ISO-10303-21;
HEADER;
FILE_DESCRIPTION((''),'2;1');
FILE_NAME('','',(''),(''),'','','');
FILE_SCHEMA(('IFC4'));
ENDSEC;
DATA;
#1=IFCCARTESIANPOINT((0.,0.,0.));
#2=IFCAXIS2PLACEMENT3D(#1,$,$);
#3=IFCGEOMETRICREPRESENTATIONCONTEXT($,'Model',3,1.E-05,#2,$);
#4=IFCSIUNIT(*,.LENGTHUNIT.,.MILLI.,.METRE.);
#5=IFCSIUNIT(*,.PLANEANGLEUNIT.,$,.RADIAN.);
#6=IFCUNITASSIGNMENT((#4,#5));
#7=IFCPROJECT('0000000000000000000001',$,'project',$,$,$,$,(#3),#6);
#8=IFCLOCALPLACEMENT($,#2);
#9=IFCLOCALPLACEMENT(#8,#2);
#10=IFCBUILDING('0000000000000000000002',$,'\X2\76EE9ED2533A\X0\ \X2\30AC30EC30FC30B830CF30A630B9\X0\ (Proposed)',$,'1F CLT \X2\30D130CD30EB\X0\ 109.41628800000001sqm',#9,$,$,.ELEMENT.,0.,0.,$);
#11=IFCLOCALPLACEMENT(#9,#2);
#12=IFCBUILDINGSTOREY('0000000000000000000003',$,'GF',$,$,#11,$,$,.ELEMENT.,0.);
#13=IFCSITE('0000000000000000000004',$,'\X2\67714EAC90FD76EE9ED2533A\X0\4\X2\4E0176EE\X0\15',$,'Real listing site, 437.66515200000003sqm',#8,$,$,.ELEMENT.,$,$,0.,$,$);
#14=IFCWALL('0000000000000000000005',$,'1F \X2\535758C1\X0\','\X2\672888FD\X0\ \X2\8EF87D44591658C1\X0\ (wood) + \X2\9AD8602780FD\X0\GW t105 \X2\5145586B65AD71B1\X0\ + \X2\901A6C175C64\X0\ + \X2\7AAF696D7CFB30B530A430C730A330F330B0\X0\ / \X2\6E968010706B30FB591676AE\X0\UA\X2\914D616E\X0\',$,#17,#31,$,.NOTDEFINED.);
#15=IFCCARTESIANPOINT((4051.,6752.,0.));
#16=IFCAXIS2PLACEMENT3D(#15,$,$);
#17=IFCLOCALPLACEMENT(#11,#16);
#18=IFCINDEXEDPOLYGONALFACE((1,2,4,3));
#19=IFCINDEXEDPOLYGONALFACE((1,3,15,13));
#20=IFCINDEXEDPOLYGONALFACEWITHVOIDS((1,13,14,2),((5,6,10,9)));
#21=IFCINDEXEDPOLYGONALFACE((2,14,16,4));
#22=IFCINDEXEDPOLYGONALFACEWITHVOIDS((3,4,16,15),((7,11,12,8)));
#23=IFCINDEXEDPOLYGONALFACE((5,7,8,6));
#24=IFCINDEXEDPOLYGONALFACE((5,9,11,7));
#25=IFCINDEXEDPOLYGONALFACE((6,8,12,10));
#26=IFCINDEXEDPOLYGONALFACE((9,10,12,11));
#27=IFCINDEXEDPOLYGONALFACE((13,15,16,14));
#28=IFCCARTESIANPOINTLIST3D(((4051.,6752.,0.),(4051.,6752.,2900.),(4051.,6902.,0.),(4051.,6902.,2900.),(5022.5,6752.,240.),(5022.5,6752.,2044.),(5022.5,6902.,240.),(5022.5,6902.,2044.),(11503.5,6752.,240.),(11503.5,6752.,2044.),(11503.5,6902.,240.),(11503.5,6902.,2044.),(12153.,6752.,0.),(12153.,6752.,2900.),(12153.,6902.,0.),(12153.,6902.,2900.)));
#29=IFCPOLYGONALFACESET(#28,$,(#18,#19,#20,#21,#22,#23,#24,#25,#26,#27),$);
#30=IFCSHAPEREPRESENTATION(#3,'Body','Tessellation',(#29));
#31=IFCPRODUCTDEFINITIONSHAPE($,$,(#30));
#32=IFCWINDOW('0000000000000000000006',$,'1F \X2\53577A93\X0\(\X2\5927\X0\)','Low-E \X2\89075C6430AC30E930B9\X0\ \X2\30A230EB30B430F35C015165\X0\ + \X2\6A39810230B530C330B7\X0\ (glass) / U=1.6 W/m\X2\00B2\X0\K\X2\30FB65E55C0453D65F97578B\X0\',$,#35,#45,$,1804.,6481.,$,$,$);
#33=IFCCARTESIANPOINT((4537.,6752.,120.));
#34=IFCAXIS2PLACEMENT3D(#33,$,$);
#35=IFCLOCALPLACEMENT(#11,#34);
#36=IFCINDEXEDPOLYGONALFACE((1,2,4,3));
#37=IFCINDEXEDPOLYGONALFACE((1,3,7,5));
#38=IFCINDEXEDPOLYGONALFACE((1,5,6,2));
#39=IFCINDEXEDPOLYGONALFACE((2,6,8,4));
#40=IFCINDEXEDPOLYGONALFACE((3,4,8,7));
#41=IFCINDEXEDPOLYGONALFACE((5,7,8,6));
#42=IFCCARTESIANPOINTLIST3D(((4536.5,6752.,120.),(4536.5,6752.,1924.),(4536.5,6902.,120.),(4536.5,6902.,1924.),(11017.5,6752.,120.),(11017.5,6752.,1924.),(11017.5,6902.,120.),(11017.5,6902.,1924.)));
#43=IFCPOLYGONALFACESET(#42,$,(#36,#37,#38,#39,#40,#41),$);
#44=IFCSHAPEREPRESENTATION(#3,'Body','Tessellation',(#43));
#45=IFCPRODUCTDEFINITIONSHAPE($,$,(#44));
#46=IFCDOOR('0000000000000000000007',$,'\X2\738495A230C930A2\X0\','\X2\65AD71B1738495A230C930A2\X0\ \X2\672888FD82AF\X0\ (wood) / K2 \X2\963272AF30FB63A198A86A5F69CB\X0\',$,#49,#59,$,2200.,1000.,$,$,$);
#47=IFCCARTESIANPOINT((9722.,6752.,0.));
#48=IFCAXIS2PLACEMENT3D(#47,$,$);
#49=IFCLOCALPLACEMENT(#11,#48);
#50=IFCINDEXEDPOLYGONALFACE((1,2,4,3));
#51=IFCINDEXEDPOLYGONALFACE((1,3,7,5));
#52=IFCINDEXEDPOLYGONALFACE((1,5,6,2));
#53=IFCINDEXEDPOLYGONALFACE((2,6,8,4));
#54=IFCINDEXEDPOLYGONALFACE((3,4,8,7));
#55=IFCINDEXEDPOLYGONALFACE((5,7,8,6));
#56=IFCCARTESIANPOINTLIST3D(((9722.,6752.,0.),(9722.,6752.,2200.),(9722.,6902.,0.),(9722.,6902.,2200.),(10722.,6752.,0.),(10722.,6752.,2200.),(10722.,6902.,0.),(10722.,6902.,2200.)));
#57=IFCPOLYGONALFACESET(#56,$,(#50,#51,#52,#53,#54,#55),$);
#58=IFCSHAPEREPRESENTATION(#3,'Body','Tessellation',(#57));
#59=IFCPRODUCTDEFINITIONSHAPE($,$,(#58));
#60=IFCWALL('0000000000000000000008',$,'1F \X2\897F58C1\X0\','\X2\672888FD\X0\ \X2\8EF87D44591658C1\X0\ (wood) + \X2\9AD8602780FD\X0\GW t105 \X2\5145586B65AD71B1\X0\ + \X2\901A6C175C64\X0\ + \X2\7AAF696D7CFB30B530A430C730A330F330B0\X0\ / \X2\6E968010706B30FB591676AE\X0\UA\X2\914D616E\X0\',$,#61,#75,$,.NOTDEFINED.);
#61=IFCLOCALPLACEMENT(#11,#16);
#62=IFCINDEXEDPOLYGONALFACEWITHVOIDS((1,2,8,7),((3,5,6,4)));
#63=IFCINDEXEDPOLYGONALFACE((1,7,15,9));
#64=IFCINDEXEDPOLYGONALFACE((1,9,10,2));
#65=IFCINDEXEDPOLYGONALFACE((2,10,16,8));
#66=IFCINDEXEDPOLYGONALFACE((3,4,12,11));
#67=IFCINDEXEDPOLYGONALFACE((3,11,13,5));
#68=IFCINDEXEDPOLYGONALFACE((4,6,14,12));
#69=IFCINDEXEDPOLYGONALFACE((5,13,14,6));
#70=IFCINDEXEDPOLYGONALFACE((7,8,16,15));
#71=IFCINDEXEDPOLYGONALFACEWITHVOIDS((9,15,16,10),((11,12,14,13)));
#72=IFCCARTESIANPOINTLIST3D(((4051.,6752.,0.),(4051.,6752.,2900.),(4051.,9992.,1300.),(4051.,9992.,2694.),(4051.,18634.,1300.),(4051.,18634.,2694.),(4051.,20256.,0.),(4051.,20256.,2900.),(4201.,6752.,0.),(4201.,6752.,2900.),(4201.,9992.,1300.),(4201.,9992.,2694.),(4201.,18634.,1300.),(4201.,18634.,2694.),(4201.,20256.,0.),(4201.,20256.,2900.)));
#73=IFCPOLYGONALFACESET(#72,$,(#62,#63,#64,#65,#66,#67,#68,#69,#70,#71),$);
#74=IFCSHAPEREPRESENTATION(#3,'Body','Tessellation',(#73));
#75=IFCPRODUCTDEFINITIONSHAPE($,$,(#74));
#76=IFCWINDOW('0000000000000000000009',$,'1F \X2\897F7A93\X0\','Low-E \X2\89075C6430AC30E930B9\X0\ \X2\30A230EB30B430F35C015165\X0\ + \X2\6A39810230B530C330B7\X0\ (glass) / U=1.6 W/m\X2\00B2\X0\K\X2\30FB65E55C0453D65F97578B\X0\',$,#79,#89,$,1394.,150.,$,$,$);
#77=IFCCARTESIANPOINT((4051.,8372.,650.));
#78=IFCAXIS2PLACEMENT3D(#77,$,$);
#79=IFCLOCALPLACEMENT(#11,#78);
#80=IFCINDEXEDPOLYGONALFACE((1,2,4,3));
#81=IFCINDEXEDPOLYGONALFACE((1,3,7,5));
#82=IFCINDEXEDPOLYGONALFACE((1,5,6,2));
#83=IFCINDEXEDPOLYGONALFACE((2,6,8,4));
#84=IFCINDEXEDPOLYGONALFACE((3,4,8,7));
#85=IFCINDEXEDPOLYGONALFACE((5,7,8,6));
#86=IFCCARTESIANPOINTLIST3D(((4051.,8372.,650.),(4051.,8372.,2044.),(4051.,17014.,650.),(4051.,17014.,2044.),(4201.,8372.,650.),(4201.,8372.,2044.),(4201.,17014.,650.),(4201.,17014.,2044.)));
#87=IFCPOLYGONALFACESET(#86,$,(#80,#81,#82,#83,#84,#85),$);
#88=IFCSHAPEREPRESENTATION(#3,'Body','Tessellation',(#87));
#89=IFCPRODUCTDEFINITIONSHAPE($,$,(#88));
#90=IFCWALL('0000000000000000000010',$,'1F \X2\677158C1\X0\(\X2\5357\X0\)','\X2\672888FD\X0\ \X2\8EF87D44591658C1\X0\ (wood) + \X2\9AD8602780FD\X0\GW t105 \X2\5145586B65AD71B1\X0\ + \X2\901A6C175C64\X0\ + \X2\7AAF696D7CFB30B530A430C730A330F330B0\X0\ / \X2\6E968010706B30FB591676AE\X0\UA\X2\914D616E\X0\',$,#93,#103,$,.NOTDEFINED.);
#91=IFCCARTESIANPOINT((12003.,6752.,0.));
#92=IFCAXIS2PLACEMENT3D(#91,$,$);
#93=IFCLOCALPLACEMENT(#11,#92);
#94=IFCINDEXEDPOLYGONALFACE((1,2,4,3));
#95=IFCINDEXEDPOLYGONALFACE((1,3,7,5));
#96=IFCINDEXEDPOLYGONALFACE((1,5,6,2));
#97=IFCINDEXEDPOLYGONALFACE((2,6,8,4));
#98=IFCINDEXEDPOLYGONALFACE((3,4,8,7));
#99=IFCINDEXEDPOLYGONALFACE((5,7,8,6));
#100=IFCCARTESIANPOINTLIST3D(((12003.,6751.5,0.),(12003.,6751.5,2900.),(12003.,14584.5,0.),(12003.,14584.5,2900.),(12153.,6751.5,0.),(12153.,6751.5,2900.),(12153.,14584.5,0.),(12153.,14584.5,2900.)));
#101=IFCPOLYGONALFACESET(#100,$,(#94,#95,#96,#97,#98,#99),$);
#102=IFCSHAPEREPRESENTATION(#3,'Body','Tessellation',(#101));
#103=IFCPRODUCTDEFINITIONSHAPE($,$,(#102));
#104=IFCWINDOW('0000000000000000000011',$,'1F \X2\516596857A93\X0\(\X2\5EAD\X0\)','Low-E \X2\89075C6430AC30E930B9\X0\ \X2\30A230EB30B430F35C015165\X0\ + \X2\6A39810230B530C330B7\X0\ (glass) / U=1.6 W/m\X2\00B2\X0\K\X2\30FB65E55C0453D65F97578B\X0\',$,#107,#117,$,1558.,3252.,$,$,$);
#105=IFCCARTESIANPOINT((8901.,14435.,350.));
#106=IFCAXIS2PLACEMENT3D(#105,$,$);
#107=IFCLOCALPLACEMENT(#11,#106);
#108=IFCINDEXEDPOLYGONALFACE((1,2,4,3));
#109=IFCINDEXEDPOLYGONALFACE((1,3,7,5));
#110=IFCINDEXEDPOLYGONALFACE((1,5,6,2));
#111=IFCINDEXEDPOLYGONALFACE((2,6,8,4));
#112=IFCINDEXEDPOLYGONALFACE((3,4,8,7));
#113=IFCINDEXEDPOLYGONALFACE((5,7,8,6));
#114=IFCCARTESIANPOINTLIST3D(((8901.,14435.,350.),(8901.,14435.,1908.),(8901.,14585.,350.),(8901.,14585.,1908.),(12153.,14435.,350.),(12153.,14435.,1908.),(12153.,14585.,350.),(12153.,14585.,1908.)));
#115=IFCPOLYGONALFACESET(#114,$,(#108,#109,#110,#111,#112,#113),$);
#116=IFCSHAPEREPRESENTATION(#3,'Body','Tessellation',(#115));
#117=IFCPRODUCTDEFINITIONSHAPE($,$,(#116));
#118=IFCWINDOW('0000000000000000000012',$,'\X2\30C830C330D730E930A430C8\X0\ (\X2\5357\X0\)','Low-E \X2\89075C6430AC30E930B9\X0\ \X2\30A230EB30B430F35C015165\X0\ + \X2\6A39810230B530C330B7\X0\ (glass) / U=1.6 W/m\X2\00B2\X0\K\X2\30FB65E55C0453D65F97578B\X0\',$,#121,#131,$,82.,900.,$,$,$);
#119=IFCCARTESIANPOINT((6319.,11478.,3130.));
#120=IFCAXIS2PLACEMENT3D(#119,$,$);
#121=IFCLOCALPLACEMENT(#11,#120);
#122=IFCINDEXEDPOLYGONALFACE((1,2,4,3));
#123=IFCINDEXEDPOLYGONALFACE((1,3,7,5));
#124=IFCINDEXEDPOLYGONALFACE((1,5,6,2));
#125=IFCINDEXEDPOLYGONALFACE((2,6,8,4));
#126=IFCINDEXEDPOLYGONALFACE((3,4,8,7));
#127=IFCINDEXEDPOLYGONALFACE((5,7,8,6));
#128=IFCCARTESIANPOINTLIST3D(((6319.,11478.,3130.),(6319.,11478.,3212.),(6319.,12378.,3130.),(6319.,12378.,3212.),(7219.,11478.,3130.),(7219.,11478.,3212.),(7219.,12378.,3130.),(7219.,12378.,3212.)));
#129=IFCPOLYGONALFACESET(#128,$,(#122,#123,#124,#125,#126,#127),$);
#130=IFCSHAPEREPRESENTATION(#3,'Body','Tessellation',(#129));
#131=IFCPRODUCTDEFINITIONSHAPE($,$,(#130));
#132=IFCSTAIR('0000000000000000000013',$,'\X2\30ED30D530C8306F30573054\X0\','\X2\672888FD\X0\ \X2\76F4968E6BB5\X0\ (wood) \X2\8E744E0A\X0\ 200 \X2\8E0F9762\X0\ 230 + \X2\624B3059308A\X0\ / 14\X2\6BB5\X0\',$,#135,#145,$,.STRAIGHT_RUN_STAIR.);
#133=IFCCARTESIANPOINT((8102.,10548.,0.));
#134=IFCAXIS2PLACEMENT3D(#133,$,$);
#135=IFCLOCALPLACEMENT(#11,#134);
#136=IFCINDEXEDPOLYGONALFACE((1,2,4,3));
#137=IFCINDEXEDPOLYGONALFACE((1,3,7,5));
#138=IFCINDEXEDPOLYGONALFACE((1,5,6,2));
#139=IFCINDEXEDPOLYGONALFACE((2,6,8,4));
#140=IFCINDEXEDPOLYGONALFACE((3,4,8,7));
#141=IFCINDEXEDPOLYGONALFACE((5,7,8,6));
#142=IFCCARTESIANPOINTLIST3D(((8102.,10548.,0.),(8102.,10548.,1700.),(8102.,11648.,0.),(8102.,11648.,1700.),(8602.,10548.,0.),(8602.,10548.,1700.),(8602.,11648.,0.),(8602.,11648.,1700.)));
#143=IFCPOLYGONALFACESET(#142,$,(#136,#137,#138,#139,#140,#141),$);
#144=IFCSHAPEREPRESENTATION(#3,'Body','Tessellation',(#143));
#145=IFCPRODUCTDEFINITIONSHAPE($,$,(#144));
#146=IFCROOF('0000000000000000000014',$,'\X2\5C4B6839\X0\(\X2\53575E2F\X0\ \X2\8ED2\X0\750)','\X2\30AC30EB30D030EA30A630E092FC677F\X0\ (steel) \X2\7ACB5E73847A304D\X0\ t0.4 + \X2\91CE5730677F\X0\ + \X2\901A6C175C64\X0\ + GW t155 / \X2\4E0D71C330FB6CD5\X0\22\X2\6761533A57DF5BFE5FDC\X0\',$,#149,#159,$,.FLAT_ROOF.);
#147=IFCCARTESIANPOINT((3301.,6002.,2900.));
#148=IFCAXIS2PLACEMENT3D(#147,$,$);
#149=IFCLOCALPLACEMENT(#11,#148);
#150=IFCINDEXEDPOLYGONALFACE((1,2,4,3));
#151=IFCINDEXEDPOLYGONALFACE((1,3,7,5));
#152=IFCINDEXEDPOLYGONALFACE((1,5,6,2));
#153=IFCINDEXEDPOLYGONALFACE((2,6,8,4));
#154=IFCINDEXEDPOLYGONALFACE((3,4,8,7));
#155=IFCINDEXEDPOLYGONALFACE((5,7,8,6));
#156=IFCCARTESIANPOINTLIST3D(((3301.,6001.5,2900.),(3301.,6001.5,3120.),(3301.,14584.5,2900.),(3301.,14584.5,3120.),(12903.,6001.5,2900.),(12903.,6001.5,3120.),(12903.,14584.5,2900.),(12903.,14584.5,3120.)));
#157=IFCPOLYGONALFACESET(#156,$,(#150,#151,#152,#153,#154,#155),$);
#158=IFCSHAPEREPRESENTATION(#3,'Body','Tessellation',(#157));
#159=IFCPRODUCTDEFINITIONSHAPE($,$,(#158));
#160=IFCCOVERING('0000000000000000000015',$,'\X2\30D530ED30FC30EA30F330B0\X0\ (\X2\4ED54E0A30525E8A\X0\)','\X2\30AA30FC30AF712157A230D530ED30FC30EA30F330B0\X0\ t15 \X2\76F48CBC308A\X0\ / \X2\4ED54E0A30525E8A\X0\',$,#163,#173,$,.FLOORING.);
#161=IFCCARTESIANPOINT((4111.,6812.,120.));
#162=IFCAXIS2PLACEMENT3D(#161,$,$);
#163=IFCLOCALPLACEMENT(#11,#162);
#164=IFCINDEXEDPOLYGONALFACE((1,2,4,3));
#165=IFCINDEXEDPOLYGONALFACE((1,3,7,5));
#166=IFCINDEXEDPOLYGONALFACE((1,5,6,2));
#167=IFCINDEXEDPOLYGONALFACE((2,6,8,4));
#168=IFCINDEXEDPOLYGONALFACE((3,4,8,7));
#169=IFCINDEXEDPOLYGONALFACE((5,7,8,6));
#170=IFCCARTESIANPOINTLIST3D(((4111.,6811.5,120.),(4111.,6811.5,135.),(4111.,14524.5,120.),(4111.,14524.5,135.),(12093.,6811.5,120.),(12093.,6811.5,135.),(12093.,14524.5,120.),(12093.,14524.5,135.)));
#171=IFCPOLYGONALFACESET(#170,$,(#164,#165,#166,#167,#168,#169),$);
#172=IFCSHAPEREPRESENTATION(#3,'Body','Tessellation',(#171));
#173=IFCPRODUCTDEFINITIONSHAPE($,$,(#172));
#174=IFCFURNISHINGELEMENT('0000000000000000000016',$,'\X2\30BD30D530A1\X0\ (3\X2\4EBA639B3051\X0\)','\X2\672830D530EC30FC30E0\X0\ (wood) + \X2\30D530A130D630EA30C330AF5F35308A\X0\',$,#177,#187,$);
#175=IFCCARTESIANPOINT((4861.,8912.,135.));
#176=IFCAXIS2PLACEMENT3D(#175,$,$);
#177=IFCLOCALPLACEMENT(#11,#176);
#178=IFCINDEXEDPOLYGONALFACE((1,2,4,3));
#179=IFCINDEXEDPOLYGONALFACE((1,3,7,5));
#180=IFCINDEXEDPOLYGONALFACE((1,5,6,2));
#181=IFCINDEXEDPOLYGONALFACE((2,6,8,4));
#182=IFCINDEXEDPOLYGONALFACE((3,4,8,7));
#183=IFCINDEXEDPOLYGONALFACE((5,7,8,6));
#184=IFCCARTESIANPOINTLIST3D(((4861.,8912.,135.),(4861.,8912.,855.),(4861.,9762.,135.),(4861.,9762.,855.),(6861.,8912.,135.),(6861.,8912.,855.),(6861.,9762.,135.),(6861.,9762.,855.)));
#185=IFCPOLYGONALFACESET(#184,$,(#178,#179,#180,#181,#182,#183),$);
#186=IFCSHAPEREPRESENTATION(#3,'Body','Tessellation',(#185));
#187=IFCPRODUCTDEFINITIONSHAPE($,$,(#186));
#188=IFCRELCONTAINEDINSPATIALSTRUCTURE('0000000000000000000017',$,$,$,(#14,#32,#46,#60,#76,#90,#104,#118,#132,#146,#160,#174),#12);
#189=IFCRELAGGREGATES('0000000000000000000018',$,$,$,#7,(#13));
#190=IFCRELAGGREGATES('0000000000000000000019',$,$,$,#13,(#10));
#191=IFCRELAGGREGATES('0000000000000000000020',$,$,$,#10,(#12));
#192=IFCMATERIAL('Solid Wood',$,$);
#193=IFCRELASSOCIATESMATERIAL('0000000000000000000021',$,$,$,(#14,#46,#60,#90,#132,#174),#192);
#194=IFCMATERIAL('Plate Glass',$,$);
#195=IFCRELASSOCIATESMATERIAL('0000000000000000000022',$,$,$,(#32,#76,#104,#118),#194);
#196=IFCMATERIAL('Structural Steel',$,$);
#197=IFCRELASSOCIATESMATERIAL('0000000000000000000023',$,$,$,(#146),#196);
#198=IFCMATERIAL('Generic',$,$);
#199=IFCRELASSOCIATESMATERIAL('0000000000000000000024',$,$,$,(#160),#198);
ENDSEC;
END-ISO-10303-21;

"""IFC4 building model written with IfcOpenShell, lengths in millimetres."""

from ifc_helpers import new_model, si_unit, frame, frame_2d, origin, place, context, project, spatial, rectangle, extrude, material, element, fill, save


model = new_model("IFC4")

# Units and contexts
model_context = context("Model", 3, precision=1e-05, world=origin())
ifc_project = project(units=[si_unit("LENGTHUNIT", "METRE", prefix="MILLI"), si_unit("PLANEANGLEUNIT", "RADIAN")], contexts=[model_context])

# Site, building, storey
site_placement = place(None, origin())
site = spatial("IfcSite", under=ifc_project, at=site_placement, Name="東京都目黒区4丁目15", ObjectType="Real listing site, 437.66515200000003sqm", CompositionType="ELEMENT", RefElevation=0.0)
building_placement = place(site_placement, origin())
building = spatial("IfcBuilding", under=site, at=building_placement, Name="目黒区 ガレージハウス (Proposed)", ObjectType="1F CLT パネル 109.41628800000001sqm", CompositionType="ELEMENT", ElevationOfRefHeight=0.0, ElevationOfTerrain=0.0)
storey_placement = place(building_placement, origin())
storey = spatial("IfcBuildingStorey", under=building, at=storey_placement, Name="GF", CompositionType="ELEMENT", Elevation=0.0)

# Shared definitions
ifc_material_1 = material(Name="Solid Wood")

# Wall, openings, window, door
wall_1_placement = place(storey_placement, frame((4051.0, 6752.0, 0.0)))
wall_1 = element("IfcWall", 1, at=wall_1_placement, inside=storey, material=ifc_material_1, Name="1F 南壁", Description="木製 軸組外壁 (wood) + 高性能GW t105 充填断熱 + 通気層 + 窯業系サイディング / 準耐火・外皮UA配慮", PredefinedType="NOTDEFINED", context=model_context, shape_type="SweptSolid", body=[
    extrude(rectangle(XDim=8102.0, YDim=150.0, at=frame_2d((4051.0, 75.0))), frame((4051.0, 6752.0, 0.0)), (0.0, 0.0, 1.0), 2900.0),
])
opening_1_placement = place(storey_placement, frame((4537.0, 6752.0, 120.0)))
opening_1 = element("IfcOpeningElement", 2, at=opening_1_placement, cuts=wall_1, PredefinedType="NOTDEFINED", context=model_context, shape_type="SweptSolid", body=[
    extrude(rectangle(XDim=6481.0, YDim=150.0, at=frame_2d((3240.0, 75.0))), frame((4537.0, 6752.0, 120.0)), (0.0, 0.0, 1.0), 1804.0),
])
opening_2_placement = place(storey_placement, frame((9722.0, 6752.0, 0.0)))
opening_2 = element("IfcOpeningElement", 3, at=opening_2_placement, cuts=wall_1, PredefinedType="NOTDEFINED", context=model_context, shape_type="SweptSolid", body=[
    extrude(rectangle(XDim=1000.0, YDim=150.0, at=frame_2d((500.0, 75.0))), frame((9722.0, 6752.0, 0.0)), (0.0, 0.0, 1.0), 2200.0),
])
ifc_material_2 = material(Name="Plate Glass")
window_1_placement = place(storey_placement, frame((4537.0, 6752.0, 120.0)))
window_1 = element("IfcWindow", 4, at=window_1_placement, inside=storey, material=ifc_material_2, Name="1F 南窓(大)", Description="Low-E 複層ガラス アルゴン封入 + 樹脂サッシ (glass) / U=1.6 W/m²K・日射取得型", OverallHeight=1804.0, OverallWidth=6481.0, context=model_context, shape_type="SweptSolid", body=[
    extrude(rectangle(XDim=6481.0, YDim=150.0, at=frame_2d((3240.0, 75.0))), frame((4537.0, 6752.0, 120.0)), (0.0, 0.0, 1.0), 1804.0),
])
fill(opening_1, window_1)
door_1_placement = place(storey_placement, frame((9722.0, 6752.0, 0.0)))
door_1 = element("IfcDoor", 5, at=door_1_placement, inside=storey, material=ifc_material_1, Name="玄関ドア", Description="断熱玄関ドア 木製芯 (wood) / K2 防犯・採風機構", OverallHeight=2200.0, OverallWidth=1000.0, context=model_context, shape_type="SweptSolid", body=[
    extrude(rectangle(XDim=1000.0, YDim=150.0, at=frame_2d((500.0, 75.0))), frame((9722.0, 6752.0, 0.0)), (0.0, 0.0, 1.0), 2200.0),
])
fill(opening_2, door_1)

# Walls, openings, windows
wall_2_placement = place(storey_placement, frame((4051.0, 6752.0, 0.0)))
wall_2 = element("IfcWall", 6, at=wall_2_placement, inside=storey, material=ifc_material_1, Name="1F 西壁", Description="木製 軸組外壁 (wood) + 高性能GW t105 充填断熱 + 通気層 + 窯業系サイディング / 準耐火・外皮UA配慮", PredefinedType="NOTDEFINED", context=model_context, shape_type="SweptSolid", body=[
    extrude(rectangle(XDim=150.0, YDim=13504.0, at=frame_2d((75.0, 6752.0))), frame((4051.0, 6752.0, 0.0)), (0.0, 0.0, 1.0), 2900.0),
])
opening_3_placement = place(storey_placement, frame((4051.0, 8372.0, 650.0)))
opening_3 = element("IfcOpeningElement", 7, at=opening_3_placement, cuts=wall_2, PredefinedType="NOTDEFINED", context=model_context, shape_type="SweptSolid", body=[
    extrude(rectangle(XDim=150.0, YDim=8642.0, at=frame_2d((75.0, 4321.0))), frame((4051.0, 8372.0, 650.0)), (0.0, 0.0, 1.0), 1394.0),
])
window_2_placement = place(storey_placement, frame((4051.0, 8372.0, 650.0)))
window_2 = element("IfcWindow", 8, at=window_2_placement, inside=storey, material=ifc_material_2, Name="1F 西窓", Description="Low-E 複層ガラス アルゴン封入 + 樹脂サッシ (glass) / U=1.6 W/m²K・日射取得型", OverallHeight=1394.0, OverallWidth=150.0, context=model_context, shape_type="SweptSolid", body=[
    extrude(rectangle(XDim=150.0, YDim=8642.0, at=frame_2d((75.0, 4321.0))), frame((4051.0, 8372.0, 650.0)), (0.0, 0.0, 1.0), 1394.0),
])
fill(opening_3, window_2)
wall_3_placement = place(storey_placement, frame((12003.0, 6752.0, 0.0)))
wall_3 = element("IfcWall", 9, at=wall_3_placement, inside=storey, material=ifc_material_1, Name="1F 東壁(南)", Description="木製 軸組外壁 (wood) + 高性能GW t105 充填断熱 + 通気層 + 窯業系サイディング / 準耐火・外皮UA配慮", PredefinedType="NOTDEFINED", context=model_context, shape_type="SweptSolid", body=[
    extrude(rectangle(XDim=150.0, YDim=7833.0, at=frame_2d((75.0, 3916.0))), frame((12003.0, 6752.0, 0.0)), (0.0, 0.0, 1.0), 2900.0),
])
opening_4_placement = place(storey_placement, frame((8901.0, 14435.0, 350.0)))
opening_4 = element("IfcOpeningElement", 10, at=opening_4_placement, cuts=wall_3, PredefinedType="NOTDEFINED", context=model_context, shape_type="SweptSolid", body=[
    extrude(rectangle(XDim=3252.0, YDim=150.0, at=frame_2d((1626.0, 75.0))), frame((8901.0, 14435.0, 350.0)), (0.0, 0.0, 1.0), 1558.0),
])
window_3_placement = place(storey_placement, frame((8901.0, 14435.0, 350.0)))
window_3 = element("IfcWindow", 11, at=window_3_placement, inside=storey, material=ifc_material_2, Name="1F 入隅窓(庭)", Description="Low-E 複層ガラス アルゴン封入 + 樹脂サッシ (glass) / U=1.6 W/m²K・日射取得型", OverallHeight=1558.0, OverallWidth=3252.0, context=model_context, shape_type="SweptSolid", body=[
    extrude(rectangle(XDim=3252.0, YDim=150.0, at=frame_2d((1626.0, 75.0))), frame((8901.0, 14435.0, 350.0)), (0.0, 0.0, 1.0), 1558.0),
])
fill(opening_4, window_3)

# Window
window_4_placement = place(storey_placement, frame((6319.0, 11478.0, 3130.0)))
element("IfcWindow", 12, at=window_4_placement, inside=storey, material=ifc_material_2, Name="トップライト (南)", Description="Low-E 複層ガラス アルゴン封入 + 樹脂サッシ (glass) / U=1.6 W/m²K・日射取得型", OverallHeight=82.0, OverallWidth=900.0, context=model_context, shape_type="SweptSolid", body=[
    extrude(rectangle(XDim=900.0, YDim=900.0, at=frame_2d((450.0, 450.0))), frame((6319.0, 11478.0, 3130.0)), (0.0, 0.0, 1.0), 82.0),
])

# Stair
stair_placement = place(storey_placement, frame((8102.0, 10548.0, 0.0)))
element("IfcStair", 13, at=stair_placement, inside=storey, material=ifc_material_1, Name="ロフトはしご", Description="木製 直階段 (wood) 蹴上 200 踏面 230 + 手すり / 14段", PredefinedType="STRAIGHT_RUN_STAIR", context=model_context, shape_type="SweptSolid", body=[
    extrude(rectangle(XDim=500.0, YDim=1100.0, at=frame_2d((250.0, 550.0))), frame((8102.0, 10548.0, 0.0)), (0.0, 0.0, 1.0), 1700.0),
])

# Roof
ifc_material_3 = material(Name="Structural Steel")
roof_placement = place(storey_placement, frame((3301.0, 6002.0, 2900.0)))
element("IfcRoof", 14, at=roof_placement, inside=storey, material=ifc_material_3, Name="屋根(南帯 軒750)", Description="ガルバリウム鋼板 (steel) 立平葺き t0.4 + 野地板 + 通気層 + GW t155 / 不燃・法22条区域対応", PredefinedType="FLAT_ROOF", context=model_context, shape_type="SweptSolid", body=[
    extrude(rectangle(XDim=9602.0, YDim=8583.0, at=frame_2d((4801.0, 4291.0))), frame((3301.0, 6002.0, 2900.0)), (0.0, 0.0, 1.0), 220.0),
])

# Covering
ifc_material_4 = material(Name="Generic")
covering_placement = place(storey_placement, frame((4111.0, 6812.0, 120.0)))
element("IfcCovering", 15, at=covering_placement, inside=storey, material=ifc_material_4, Name="フローリング (仕上げ床)", Description="オーク無垢フローリング t15 直貼り / 仕上げ床", PredefinedType="FLOORING", context=model_context, shape_type="SweptSolid", body=[
    extrude(rectangle(XDim=7982.0, YDim=7713.0, at=frame_2d((3991.0, 3856.0))), frame((4111.0, 6812.0, 120.0)), (0.0, 0.0, 1.0), 15.0),
])

# Furnishing element
furnishing_1_placement = place(storey_placement, frame((4861.0, 8912.0, 135.0)))
element("IfcFurnishingElement", 16, at=furnishing_1_placement, inside=storey, material=ifc_material_1, Name="ソファ (3人掛け)", Description="木フレーム (wood) + ファブリック張り", context=model_context, shape_type="SweptSolid", body=[
    extrude(rectangle(XDim=2000.0, YDim=850.0, at=frame_2d((1000.0, 425.0))), frame((4861.0, 8912.0, 135.0)), (0.0, 0.0, 1.0), 720.0),
])

save(model, "model.ifc")
